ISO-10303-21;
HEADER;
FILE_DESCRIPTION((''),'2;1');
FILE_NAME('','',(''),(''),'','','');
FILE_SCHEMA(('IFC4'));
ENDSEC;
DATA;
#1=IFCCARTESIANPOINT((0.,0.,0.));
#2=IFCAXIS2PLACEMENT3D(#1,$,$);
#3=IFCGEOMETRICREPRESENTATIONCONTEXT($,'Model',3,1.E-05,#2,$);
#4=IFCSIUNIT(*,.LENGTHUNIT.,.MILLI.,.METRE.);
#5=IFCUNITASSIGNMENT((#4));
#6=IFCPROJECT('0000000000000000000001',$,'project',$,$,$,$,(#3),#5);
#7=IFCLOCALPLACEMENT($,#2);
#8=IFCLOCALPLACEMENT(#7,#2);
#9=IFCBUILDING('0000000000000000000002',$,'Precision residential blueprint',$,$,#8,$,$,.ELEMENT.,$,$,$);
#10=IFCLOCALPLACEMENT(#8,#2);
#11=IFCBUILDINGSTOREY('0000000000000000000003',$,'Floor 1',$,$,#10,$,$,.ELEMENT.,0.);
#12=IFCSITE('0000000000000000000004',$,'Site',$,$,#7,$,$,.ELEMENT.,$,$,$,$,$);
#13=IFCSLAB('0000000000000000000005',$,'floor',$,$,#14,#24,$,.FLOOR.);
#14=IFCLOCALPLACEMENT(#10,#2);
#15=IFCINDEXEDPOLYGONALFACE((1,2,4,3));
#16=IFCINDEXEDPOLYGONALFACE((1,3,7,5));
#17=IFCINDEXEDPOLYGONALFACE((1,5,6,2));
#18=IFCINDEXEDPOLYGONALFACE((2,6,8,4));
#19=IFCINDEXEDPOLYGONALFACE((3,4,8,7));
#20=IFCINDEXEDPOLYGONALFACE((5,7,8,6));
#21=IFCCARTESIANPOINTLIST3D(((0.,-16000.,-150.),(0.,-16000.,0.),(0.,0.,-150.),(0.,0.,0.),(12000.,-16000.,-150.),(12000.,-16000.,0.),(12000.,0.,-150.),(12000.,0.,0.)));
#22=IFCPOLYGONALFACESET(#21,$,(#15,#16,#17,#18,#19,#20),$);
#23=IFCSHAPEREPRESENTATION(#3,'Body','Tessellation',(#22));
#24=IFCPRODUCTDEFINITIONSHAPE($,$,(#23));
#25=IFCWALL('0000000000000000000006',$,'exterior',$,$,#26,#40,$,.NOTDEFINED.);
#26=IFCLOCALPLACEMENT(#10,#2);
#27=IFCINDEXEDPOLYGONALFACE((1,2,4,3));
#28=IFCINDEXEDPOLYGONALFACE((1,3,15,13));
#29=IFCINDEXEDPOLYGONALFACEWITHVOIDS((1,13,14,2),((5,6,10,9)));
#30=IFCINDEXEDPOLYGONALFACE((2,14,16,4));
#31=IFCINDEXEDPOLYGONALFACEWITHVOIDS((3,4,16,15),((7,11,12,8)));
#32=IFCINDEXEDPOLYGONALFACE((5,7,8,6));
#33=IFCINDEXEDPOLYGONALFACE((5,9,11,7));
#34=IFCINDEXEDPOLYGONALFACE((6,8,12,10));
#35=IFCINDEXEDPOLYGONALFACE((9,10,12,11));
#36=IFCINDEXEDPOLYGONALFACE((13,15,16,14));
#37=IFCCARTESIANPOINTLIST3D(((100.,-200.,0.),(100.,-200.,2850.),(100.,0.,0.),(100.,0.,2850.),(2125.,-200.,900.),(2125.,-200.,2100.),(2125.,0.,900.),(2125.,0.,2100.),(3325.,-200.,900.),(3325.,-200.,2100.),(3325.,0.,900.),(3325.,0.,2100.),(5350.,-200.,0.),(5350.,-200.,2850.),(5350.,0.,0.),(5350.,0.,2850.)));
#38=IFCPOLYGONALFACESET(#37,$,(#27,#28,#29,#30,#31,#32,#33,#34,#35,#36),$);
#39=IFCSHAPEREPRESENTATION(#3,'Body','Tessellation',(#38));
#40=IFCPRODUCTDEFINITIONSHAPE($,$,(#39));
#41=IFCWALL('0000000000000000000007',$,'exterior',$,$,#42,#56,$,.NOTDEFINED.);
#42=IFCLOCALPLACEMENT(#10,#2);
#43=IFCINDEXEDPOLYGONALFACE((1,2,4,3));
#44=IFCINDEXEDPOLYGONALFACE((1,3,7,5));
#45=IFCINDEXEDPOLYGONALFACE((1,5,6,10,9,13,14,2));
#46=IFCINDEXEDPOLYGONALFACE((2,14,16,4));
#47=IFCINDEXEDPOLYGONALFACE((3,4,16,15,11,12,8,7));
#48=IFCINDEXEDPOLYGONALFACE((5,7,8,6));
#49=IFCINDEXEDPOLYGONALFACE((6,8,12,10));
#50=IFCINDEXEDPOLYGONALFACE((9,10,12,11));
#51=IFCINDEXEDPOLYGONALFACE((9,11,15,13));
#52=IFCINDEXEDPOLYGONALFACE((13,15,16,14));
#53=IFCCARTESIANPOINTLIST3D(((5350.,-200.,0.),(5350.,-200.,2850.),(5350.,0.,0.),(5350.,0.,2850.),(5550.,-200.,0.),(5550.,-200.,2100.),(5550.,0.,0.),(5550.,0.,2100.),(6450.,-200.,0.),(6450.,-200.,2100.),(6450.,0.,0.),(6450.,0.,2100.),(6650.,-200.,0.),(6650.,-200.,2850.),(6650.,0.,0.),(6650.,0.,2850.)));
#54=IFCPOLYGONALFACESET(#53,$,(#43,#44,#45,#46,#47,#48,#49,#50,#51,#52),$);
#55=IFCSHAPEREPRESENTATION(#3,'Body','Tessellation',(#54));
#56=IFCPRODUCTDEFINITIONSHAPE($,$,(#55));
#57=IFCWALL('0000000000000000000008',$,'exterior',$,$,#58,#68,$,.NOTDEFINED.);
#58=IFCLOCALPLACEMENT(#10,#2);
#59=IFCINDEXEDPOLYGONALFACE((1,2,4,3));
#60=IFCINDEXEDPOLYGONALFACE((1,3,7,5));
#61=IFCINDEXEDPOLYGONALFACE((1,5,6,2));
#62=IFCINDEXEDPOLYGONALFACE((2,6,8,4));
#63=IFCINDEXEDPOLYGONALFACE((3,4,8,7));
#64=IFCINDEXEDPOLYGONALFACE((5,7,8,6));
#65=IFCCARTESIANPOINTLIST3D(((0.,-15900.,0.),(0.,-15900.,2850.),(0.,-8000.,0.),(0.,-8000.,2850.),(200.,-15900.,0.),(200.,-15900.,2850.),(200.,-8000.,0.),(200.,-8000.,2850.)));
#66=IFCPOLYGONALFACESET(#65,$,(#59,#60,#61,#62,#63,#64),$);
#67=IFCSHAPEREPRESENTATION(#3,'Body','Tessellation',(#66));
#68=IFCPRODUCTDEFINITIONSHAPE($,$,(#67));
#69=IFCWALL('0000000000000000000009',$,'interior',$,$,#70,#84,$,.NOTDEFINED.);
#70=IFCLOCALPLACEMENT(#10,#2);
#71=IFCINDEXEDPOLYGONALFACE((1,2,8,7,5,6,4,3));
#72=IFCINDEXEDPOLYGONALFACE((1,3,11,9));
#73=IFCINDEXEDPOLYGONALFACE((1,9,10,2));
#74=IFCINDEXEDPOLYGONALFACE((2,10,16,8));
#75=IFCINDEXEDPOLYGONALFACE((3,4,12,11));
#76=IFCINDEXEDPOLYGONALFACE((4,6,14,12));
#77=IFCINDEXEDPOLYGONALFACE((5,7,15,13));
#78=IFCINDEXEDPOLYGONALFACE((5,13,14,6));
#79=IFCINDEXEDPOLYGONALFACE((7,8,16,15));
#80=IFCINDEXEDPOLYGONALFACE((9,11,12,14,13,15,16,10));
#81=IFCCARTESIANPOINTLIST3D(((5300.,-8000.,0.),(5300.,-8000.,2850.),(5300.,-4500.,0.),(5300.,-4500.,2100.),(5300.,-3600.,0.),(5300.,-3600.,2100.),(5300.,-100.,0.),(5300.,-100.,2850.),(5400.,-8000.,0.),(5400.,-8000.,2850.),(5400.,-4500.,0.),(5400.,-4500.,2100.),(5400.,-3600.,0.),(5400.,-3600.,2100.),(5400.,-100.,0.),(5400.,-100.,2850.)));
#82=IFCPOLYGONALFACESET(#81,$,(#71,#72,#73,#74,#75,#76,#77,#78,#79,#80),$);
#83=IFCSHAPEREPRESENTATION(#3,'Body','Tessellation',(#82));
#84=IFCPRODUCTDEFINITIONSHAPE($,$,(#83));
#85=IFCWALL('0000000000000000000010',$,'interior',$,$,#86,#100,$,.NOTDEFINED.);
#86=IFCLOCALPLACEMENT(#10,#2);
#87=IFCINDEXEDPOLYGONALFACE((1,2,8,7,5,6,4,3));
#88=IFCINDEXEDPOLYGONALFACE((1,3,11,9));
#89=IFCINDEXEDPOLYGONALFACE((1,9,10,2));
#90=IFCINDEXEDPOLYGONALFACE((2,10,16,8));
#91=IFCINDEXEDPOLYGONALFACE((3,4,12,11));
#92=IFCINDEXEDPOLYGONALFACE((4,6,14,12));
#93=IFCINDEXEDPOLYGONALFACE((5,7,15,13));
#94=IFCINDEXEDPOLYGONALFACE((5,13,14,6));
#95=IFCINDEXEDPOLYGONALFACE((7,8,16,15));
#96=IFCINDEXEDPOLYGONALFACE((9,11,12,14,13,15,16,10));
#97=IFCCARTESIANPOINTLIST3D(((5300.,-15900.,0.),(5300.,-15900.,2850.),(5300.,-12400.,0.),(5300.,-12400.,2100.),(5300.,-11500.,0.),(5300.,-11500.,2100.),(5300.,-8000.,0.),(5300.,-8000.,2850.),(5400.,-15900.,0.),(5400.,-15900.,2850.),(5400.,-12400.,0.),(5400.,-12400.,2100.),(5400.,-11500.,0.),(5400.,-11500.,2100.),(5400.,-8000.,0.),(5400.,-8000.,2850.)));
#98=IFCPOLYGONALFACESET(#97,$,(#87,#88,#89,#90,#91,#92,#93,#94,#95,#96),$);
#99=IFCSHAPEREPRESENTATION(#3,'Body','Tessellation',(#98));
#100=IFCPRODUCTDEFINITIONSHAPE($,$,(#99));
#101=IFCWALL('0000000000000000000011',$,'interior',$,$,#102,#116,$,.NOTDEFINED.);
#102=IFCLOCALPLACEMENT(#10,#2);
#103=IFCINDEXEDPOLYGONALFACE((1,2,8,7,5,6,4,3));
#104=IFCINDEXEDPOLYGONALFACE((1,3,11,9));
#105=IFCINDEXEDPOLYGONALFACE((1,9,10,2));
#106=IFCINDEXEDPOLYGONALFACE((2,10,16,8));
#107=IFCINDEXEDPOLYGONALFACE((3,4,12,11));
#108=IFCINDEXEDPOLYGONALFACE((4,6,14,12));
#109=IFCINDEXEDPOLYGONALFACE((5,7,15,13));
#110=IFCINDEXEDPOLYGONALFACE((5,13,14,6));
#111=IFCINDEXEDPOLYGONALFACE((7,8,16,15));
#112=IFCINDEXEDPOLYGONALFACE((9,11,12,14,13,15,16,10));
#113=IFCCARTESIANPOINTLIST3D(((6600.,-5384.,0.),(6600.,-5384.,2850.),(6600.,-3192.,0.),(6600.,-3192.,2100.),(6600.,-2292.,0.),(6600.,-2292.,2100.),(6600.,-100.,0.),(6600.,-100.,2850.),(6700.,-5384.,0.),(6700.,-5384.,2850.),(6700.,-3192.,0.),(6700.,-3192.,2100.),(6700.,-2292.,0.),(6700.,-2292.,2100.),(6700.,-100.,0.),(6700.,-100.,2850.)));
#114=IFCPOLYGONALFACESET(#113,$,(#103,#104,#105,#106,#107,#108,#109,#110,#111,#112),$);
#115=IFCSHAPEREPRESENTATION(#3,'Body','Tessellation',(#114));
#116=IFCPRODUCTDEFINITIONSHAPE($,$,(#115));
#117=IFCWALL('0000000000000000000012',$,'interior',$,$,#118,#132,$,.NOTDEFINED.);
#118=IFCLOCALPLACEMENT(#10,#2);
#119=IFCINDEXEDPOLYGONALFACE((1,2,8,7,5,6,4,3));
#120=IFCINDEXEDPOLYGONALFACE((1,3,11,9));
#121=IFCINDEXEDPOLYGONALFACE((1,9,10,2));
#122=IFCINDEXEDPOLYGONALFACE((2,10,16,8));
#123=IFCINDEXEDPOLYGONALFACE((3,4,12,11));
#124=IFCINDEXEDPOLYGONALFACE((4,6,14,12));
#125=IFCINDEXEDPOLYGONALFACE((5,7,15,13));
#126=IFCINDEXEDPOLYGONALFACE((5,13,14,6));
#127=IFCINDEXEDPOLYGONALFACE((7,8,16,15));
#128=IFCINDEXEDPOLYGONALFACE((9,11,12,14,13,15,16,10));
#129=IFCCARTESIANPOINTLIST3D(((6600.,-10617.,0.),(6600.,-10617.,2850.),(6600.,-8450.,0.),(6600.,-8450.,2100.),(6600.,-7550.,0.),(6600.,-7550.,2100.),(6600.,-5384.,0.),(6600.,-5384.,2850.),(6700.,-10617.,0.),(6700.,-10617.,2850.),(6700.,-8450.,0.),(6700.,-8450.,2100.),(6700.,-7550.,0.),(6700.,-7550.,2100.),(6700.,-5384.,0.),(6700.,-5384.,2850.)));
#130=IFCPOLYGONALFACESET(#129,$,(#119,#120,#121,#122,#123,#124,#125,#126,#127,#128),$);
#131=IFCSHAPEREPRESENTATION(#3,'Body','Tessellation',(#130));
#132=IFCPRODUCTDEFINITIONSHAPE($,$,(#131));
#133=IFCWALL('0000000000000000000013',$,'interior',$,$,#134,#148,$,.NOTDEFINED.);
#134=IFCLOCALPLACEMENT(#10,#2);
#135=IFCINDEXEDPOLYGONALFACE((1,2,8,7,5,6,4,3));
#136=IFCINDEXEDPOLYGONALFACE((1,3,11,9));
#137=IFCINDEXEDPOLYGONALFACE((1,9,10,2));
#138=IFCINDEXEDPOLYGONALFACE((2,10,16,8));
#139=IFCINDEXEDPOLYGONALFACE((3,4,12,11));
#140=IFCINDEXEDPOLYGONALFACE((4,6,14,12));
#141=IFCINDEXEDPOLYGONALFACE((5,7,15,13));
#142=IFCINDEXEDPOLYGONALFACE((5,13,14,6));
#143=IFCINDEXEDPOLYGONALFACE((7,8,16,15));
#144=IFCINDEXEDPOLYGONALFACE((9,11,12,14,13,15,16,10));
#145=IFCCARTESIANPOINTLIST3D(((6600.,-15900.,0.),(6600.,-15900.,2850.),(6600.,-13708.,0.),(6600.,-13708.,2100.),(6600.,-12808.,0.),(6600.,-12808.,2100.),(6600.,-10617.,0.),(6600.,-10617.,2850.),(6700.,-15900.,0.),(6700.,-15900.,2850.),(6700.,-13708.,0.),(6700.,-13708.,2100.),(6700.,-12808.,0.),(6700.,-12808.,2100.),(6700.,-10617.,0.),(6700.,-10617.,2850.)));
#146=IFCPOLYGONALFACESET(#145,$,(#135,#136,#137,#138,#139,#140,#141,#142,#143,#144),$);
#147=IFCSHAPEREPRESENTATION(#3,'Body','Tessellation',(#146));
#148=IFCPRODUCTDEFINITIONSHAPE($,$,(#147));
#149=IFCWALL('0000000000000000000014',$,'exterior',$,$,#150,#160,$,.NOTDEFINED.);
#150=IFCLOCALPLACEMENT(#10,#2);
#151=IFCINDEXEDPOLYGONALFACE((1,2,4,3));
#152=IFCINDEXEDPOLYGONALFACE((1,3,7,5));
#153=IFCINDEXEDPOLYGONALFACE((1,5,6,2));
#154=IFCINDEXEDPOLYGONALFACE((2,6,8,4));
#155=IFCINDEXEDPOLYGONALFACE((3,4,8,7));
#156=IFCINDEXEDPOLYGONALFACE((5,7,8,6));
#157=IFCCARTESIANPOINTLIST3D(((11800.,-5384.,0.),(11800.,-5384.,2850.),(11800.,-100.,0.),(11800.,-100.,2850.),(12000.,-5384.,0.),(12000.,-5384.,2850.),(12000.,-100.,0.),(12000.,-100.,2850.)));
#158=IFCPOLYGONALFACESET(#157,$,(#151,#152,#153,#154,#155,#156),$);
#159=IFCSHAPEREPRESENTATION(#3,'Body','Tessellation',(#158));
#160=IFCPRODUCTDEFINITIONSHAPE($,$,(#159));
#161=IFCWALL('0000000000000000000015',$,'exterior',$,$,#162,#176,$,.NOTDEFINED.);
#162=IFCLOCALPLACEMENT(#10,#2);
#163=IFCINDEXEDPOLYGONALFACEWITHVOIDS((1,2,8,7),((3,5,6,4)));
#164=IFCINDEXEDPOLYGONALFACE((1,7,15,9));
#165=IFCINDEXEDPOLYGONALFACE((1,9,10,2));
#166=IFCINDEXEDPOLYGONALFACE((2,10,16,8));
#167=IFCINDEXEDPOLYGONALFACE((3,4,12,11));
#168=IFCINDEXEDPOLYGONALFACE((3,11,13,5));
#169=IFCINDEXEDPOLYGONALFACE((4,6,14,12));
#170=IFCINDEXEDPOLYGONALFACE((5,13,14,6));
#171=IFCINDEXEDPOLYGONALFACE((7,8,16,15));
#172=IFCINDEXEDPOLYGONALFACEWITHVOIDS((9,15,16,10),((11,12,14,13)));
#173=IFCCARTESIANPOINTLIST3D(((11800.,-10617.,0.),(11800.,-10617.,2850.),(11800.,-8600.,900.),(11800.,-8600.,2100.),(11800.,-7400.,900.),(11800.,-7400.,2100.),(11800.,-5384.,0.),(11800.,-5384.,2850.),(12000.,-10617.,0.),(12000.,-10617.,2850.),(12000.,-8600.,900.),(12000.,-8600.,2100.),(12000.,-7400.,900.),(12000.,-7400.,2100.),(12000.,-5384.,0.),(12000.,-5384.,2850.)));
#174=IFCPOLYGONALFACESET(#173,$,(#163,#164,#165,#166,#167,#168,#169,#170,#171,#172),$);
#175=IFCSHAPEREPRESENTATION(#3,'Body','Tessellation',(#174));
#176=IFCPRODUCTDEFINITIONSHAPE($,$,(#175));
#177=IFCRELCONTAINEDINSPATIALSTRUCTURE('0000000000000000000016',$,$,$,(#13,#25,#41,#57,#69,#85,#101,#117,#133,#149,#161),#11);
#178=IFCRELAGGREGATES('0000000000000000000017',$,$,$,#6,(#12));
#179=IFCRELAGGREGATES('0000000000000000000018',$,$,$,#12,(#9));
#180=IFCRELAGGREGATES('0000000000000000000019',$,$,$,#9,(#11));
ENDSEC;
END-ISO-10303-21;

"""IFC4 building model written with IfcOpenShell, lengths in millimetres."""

from ifc_helpers import new_model, si_unit, frame, origin, place, context, project, spatial, polyline, outline, extrude, element, save


model = new_model("IFC4")

# Units and contexts
model_context = context("Model", 3, precision=1e-05, world=origin())
ifc_project = project(units=[si_unit("LENGTHUNIT", "METRE", prefix="MILLI")], contexts=[model_context])

# Site, building, storey
site_placement = place(None, origin())
site = spatial("IfcSite", under=ifc_project, at=site_placement, Name="Site", CompositionType="ELEMENT")
building_placement = place(site_placement, origin())
building = spatial("IfcBuilding", under=site, at=building_placement, Name="Precision residential blueprint", CompositionType="ELEMENT")
storey_placement = place(building_placement, origin())
storey = spatial("IfcBuildingStorey", under=building, at=storey_placement, Name="Floor 1", CompositionType="ELEMENT", Elevation=0.0)

# Slab
slab_placement = place(storey_placement, origin())
element("IfcSlab", 1, at=slab_placement, inside=storey, Name="floor", PredefinedType="FLOOR", context=model_context, shape_type="SweptSolid", body=[
    extrude(outline(polyline([(0.0, -16000.0), (12000.0, -16000.0), (12000.0, 0.0), (0.0, 0.0), (0.0, -16000.0)])), frame((0.0, 0.0, -150.0)), (0.0, 0.0, 1.0), 150.0),
])

# Walls, openings
wall_1_placement = place(storey_placement, origin())
wall_1 = element("IfcWall", 2, at=wall_1_placement, inside=storey, Name="exterior", PredefinedType="NOTDEFINED", context=model_context, shape_type="SweptSolid", body=[
    extrude(outline(polyline([(100.0, 0.0), (5350.0, 0.0), (5350.0, -200.0), (100.0, -200.0), (100.0, 0.0)])), origin(), (0.0, 0.0, 1.0), 2850.0),
])
opening_1_placement = place(storey_placement, origin())
element("IfcOpeningElement", 3, at=opening_1_placement, cuts=wall_1, PredefinedType="OPENING", context=model_context, shape_type="SweptSolid", body=[
    extrude(outline(polyline([(2125.0, 0.0), (3325.0, 0.0), (3325.0, -200.0), (2125.0, -200.0), (2125.0, 0.0)])), frame((0.0, 0.0, 900.0)), (0.0, 0.0, 1.0), 1200.0),
])
wall_2_placement = place(storey_placement, origin())
wall_2 = element("IfcWall", 4, at=wall_2_placement, inside=storey, Name="exterior", PredefinedType="NOTDEFINED", context=model_context, shape_type="SweptSolid", body=[
    extrude(outline(polyline([(5350.0, 0.0), (6650.0, 0.0), (6650.0, -200.0), (5350.0, -200.0), (5350.0, 0.0)])), origin(), (0.0, 0.0, 1.0), 2850.0),
])
opening_2_placement = place(storey_placement, origin())
element("IfcOpeningElement", 5, at=opening_2_placement, cuts=wall_2, PredefinedType="OPENING", context=model_context, shape_type="SweptSolid", body=[
    extrude(outline(polyline([(5550.0, 0.0), (6450.0, 0.0), (6450.0, -200.0), (5550.0, -200.0), (5550.0, 0.0)])), origin(), (0.0, 0.0, 1.0), 2100.0),
])

# Wall
wall_3_placement = place(storey_placement, origin())
element("IfcWall", 6, at=wall_3_placement, inside=storey, Name="exterior", PredefinedType="NOTDEFINED", context=model_context, shape_type="SweptSolid", body=[
    extrude(outline(polyline([(200.0, -8000.0), (200.0, -15900.0), (0.0, -15900.0), (0.0, -8000.0), (200.0, -8000.0)])), origin(), (0.0, 0.0, 1.0), 2850.0),
])

# Walls, openings
wall_4_placement = place(storey_placement, origin())
wall_4 = element("IfcWall", 7, at=wall_4_placement, inside=storey, Name="interior", PredefinedType="NOTDEFINED", context=model_context, shape_type="SweptSolid", body=[
    extrude(outline(polyline([(5400.0, -100.0), (5400.0, -8000.0), (5300.0, -8000.0), (5300.0, -100.0), (5400.0, -100.0)])), origin(), (0.0, 0.0, 1.0), 2850.0),
])
opening_3_placement = place(storey_placement, origin())
element("IfcOpeningElement", 8, at=opening_3_placement, cuts=wall_4, PredefinedType="OPENING", context=model_context, shape_type="SweptSolid", body=[
    extrude(outline(polyline([(5400.0, -3600.0), (5400.0, -4500.0), (5300.0, -4500.0), (5300.0, -3600.0), (5400.0, -3600.0)])), origin(), (0.0, 0.0, 1.0), 2100.0),
])
wall_5_placement = place(storey_placement, origin())
wall_5 = element("IfcWall", 9, at=wall_5_placement, inside=storey, Name="interior", PredefinedType="NOTDEFINED", context=model_context, shape_type="SweptSolid", body=[
    extrude(outline(polyline([(5400.0, -8000.0), (5400.0, -15900.0), (5300.0, -15900.0), (5300.0, -8000.0), (5400.0, -8000.0)])), origin(), (0.0, 0.0, 1.0), 2850.0),
])
opening_4_placement = place(storey_placement, origin())
element("IfcOpeningElement", 10, at=opening_4_placement, cuts=wall_5, PredefinedType="OPENING", context=model_context, shape_type="SweptSolid", body=[
    extrude(outline(polyline([(5400.0, -11500.0), (5400.0, -12400.0), (5300.0, -12400.0), (5300.0, -11500.0), (5400.0, -11500.0)])), origin(), (0.0, 0.0, 1.0), 2100.0),
])
wall_6_placement = place(storey_placement, origin())
wall_6 = element("IfcWall", 11, at=wall_6_placement, inside=storey, Name="interior", PredefinedType="NOTDEFINED", context=model_context, shape_type="SweptSolid", body=[
    extrude(outline(polyline([(6700.0, -100.0), (6700.0, -5384.0), (6600.0, -5384.0), (6600.0, -100.0), (6700.0, -100.0)])), origin(), (0.0, 0.0, 1.0), 2850.0),
])
opening_5_placement = place(storey_placement, origin())
element("IfcOpeningElement", 12, at=opening_5_placement, cuts=wall_6, PredefinedType="OPENING", context=model_context, shape_type="SweptSolid", body=[
    extrude(outline(polyline([(6700.0, -2292.0), (6700.0, -3192.0), (6600.0, -3192.0), (6600.0, -2292.0), (6700.0, -2292.0)])), origin(), (0.0, 0.0, 1.0), 2100.0),
])
wall_7_placement = place(storey_placement, origin())
wall_7 = element("IfcWall", 13, at=wall_7_placement, inside=storey, Name="interior", PredefinedType="NOTDEFINED", context=model_context, shape_type="SweptSolid", body=[
    extrude(outline(polyline([(6700.0, -5384.0), (6700.0, -10617.0), (6600.0, -10617.0), (6600.0, -5384.0), (6700.0, -5384.0)])), origin(), (0.0, 0.0, 1.0), 2850.0),
])
opening_6_placement = place(storey_placement, origin())
element("IfcOpeningElement", 14, at=opening_6_placement, cuts=wall_7, PredefinedType="OPENING", context=model_context, shape_type="SweptSolid", body=[
    extrude(outline(polyline([(6700.0, -7550.0), (6700.0, -8450.0), (6600.0, -8450.0), (6600.0, -7550.0), (6700.0, -7550.0)])), origin(), (0.0, 0.0, 1.0), 2100.0),
])
wall_8_placement = place(storey_placement, origin())
wall_8 = element("IfcWall", 15, at=wall_8_placement, inside=storey, Name="interior", PredefinedType="NOTDEFINED", context=model_context, shape_type="SweptSolid", body=[
    extrude(outline(polyline([(6700.0, -10617.0), (6700.0, -15900.0), (6600.0, -15900.0), (6600.0, -10617.0), (6700.0, -10617.0)])), origin(), (0.0, 0.0, 1.0), 2850.0),
])
opening_7_placement = place(storey_placement, origin())
element("IfcOpeningElement", 16, at=opening_7_placement, cuts=wall_8, PredefinedType="OPENING", context=model_context, shape_type="SweptSolid", body=[
    extrude(outline(polyline([(6700.0, -12808.0), (6700.0, -13708.0), (6600.0, -13708.0), (6600.0, -12808.0), (6700.0, -12808.0)])), origin(), (0.0, 0.0, 1.0), 2100.0),
])

# Wall
wall_9_placement = place(storey_placement, origin())
element("IfcWall", 17, at=wall_9_placement, inside=storey, Name="exterior", PredefinedType="NOTDEFINED", context=model_context, shape_type="SweptSolid", body=[
    extrude(outline(polyline([(12000.0, -100.0), (12000.0, -5384.0), (11800.0, -5384.0), (11800.0, -100.0), (12000.0, -100.0)])), origin(), (0.0, 0.0, 1.0), 2850.0),
])

# Wall, opening
wall_10_placement = place(storey_placement, origin())
wall_10 = element("IfcWall", 18, at=wall_10_placement, inside=storey, Name="exterior", PredefinedType="NOTDEFINED", context=model_context, shape_type="SweptSolid", body=[
    extrude(outline(polyline([(12000.0, -5384.0), (12000.0, -10617.0), (11800.0, -10617.0), (11800.0, -5384.0), (12000.0, -5384.0)])), origin(), (0.0, 0.0, 1.0), 2850.0),
])
opening_8_placement = place(storey_placement, origin())
element("IfcOpeningElement", 19, at=opening_8_placement, cuts=wall_10, PredefinedType="OPENING", context=model_context, shape_type="SweptSolid", body=[
    extrude(outline(polyline([(12000.0, -7400.0), (12000.0, -8600.0), (11800.0, -8600.0), (11800.0, -7400.0), (12000.0, -7400.0)])), frame((0.0, 0.0, 900.0)), (0.0, 0.0, 1.0), 1200.0),
])

save(model, "model.ifc")
